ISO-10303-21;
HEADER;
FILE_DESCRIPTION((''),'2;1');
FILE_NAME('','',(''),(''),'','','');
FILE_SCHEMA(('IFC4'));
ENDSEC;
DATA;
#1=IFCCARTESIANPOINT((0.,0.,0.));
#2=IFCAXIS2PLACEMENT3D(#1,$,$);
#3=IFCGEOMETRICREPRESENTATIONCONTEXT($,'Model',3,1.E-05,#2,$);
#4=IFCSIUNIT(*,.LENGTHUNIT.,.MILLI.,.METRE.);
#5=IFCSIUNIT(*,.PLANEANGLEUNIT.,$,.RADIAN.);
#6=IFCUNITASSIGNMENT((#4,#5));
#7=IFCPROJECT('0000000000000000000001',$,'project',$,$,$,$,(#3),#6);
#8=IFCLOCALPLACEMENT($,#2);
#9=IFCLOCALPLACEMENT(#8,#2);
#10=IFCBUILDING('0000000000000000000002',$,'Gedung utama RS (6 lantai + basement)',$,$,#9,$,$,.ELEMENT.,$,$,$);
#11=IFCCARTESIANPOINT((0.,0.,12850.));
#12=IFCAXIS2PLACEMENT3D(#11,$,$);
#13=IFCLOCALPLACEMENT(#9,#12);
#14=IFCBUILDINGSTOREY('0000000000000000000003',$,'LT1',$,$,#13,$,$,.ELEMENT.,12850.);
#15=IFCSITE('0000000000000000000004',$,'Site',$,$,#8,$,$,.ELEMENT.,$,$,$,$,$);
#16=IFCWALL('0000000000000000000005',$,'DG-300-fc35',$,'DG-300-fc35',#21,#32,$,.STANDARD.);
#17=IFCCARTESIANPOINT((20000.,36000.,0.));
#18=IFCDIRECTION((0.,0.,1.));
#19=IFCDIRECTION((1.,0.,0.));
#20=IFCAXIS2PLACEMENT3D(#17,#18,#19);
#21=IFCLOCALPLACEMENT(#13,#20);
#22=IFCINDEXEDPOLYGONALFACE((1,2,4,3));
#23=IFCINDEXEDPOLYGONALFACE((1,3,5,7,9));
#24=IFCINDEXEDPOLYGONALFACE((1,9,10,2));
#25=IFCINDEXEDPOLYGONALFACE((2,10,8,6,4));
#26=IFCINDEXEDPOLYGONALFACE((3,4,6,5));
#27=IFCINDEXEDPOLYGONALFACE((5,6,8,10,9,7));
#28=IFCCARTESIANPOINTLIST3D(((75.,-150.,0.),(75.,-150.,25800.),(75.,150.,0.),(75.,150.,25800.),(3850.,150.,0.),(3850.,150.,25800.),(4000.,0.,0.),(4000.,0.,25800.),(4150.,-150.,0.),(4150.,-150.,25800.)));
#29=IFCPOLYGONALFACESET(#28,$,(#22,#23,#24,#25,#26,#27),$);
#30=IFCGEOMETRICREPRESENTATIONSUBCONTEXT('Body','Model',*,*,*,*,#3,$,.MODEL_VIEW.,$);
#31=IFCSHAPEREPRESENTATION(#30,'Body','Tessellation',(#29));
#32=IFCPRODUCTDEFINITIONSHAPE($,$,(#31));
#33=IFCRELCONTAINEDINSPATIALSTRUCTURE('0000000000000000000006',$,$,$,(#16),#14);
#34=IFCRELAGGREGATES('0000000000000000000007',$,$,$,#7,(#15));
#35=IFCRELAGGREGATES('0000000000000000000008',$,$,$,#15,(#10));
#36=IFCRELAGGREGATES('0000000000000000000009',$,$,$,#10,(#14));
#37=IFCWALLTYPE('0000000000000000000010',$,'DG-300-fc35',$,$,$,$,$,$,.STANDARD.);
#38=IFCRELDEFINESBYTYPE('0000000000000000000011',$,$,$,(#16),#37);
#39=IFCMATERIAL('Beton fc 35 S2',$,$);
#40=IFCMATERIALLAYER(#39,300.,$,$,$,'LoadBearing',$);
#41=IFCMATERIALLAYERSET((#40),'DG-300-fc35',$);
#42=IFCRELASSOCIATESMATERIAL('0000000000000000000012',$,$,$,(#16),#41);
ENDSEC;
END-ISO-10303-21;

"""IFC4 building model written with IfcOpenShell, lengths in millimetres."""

from ifc_helpers import new_model, si_unit, frame, origin, place, context, subcontext, project, spatial, polyline, outline, extrude, material, layer, layer_set, layer_usage, type_object, element, save


model = new_model("IFC4")

# Units and contexts
model_context = context("Model", 3, precision=1e-05, world=origin())
body_context = subcontext(model_context, "Body", "Model", "MODEL_VIEW")
ifc_project = project(units=[si_unit("LENGTHUNIT", "METRE", prefix="MILLI"), si_unit("PLANEANGLEUNIT", "RADIAN")], contexts=[model_context])

# Site, building, storey
site_placement = place(None, origin())
site = spatial("IfcSite", under=ifc_project, at=site_placement, Name="Site", CompositionType="ELEMENT")
building_placement = place(site_placement, origin())
building = spatial("IfcBuilding", under=site, at=building_placement, Name="Gedung utama RS (6 lantai + basement)", CompositionType="ELEMENT")
storey_placement = place(building_placement, frame((0.0, 0.0, 12850.0)))
storey = spatial("IfcBuildingStorey", under=building, at=storey_placement, Name="LT1", CompositionType="ELEMENT", Elevation=12850.0)

# Wall
ifc_material_1 = material(Name="Beton fc 35 S2")
ifc_layer_1 = layer(ifc_material_1, 300.0, Category="LoadBearing")
ifc_layer_set_1 = layer_set([ifc_layer_1], Name="DG-300-fc35")
ifc_layer_usage_1 = layer_usage(ifc_layer_set_1, "AXIS2", "NEGATIVE", 150.0)
wall_type_1 = type_object("IfcWallType", Name="DG-300-fc35", PredefinedType="STANDARD")
wall_1_placement = place(storey_placement, frame((20000.0, 36000.0, 0.0), z_axis=(0.0, 0.0, 1.0), x_axis=(1.0, 0.0, 0.0)))
element("IfcWall", 1, at=wall_1_placement, inside=storey, type_object=wall_type_1, material=ifc_layer_usage_1, Name="DG-300-fc35", ObjectType="DG-300-fc35", PredefinedType="STANDARD", context=body_context, shape_type="SweptSolid", body=[
    extrude(outline(polyline([(75.0, -150.0), (75.0, 150.0), (3850.0, 150.0), (4000.0, 0.0), (4150.0, -150.0), (75.0, -150.0)])), origin(), (0.0, 0.0, 1.0), 25800.0),
])

save(model, "model.ifc")
